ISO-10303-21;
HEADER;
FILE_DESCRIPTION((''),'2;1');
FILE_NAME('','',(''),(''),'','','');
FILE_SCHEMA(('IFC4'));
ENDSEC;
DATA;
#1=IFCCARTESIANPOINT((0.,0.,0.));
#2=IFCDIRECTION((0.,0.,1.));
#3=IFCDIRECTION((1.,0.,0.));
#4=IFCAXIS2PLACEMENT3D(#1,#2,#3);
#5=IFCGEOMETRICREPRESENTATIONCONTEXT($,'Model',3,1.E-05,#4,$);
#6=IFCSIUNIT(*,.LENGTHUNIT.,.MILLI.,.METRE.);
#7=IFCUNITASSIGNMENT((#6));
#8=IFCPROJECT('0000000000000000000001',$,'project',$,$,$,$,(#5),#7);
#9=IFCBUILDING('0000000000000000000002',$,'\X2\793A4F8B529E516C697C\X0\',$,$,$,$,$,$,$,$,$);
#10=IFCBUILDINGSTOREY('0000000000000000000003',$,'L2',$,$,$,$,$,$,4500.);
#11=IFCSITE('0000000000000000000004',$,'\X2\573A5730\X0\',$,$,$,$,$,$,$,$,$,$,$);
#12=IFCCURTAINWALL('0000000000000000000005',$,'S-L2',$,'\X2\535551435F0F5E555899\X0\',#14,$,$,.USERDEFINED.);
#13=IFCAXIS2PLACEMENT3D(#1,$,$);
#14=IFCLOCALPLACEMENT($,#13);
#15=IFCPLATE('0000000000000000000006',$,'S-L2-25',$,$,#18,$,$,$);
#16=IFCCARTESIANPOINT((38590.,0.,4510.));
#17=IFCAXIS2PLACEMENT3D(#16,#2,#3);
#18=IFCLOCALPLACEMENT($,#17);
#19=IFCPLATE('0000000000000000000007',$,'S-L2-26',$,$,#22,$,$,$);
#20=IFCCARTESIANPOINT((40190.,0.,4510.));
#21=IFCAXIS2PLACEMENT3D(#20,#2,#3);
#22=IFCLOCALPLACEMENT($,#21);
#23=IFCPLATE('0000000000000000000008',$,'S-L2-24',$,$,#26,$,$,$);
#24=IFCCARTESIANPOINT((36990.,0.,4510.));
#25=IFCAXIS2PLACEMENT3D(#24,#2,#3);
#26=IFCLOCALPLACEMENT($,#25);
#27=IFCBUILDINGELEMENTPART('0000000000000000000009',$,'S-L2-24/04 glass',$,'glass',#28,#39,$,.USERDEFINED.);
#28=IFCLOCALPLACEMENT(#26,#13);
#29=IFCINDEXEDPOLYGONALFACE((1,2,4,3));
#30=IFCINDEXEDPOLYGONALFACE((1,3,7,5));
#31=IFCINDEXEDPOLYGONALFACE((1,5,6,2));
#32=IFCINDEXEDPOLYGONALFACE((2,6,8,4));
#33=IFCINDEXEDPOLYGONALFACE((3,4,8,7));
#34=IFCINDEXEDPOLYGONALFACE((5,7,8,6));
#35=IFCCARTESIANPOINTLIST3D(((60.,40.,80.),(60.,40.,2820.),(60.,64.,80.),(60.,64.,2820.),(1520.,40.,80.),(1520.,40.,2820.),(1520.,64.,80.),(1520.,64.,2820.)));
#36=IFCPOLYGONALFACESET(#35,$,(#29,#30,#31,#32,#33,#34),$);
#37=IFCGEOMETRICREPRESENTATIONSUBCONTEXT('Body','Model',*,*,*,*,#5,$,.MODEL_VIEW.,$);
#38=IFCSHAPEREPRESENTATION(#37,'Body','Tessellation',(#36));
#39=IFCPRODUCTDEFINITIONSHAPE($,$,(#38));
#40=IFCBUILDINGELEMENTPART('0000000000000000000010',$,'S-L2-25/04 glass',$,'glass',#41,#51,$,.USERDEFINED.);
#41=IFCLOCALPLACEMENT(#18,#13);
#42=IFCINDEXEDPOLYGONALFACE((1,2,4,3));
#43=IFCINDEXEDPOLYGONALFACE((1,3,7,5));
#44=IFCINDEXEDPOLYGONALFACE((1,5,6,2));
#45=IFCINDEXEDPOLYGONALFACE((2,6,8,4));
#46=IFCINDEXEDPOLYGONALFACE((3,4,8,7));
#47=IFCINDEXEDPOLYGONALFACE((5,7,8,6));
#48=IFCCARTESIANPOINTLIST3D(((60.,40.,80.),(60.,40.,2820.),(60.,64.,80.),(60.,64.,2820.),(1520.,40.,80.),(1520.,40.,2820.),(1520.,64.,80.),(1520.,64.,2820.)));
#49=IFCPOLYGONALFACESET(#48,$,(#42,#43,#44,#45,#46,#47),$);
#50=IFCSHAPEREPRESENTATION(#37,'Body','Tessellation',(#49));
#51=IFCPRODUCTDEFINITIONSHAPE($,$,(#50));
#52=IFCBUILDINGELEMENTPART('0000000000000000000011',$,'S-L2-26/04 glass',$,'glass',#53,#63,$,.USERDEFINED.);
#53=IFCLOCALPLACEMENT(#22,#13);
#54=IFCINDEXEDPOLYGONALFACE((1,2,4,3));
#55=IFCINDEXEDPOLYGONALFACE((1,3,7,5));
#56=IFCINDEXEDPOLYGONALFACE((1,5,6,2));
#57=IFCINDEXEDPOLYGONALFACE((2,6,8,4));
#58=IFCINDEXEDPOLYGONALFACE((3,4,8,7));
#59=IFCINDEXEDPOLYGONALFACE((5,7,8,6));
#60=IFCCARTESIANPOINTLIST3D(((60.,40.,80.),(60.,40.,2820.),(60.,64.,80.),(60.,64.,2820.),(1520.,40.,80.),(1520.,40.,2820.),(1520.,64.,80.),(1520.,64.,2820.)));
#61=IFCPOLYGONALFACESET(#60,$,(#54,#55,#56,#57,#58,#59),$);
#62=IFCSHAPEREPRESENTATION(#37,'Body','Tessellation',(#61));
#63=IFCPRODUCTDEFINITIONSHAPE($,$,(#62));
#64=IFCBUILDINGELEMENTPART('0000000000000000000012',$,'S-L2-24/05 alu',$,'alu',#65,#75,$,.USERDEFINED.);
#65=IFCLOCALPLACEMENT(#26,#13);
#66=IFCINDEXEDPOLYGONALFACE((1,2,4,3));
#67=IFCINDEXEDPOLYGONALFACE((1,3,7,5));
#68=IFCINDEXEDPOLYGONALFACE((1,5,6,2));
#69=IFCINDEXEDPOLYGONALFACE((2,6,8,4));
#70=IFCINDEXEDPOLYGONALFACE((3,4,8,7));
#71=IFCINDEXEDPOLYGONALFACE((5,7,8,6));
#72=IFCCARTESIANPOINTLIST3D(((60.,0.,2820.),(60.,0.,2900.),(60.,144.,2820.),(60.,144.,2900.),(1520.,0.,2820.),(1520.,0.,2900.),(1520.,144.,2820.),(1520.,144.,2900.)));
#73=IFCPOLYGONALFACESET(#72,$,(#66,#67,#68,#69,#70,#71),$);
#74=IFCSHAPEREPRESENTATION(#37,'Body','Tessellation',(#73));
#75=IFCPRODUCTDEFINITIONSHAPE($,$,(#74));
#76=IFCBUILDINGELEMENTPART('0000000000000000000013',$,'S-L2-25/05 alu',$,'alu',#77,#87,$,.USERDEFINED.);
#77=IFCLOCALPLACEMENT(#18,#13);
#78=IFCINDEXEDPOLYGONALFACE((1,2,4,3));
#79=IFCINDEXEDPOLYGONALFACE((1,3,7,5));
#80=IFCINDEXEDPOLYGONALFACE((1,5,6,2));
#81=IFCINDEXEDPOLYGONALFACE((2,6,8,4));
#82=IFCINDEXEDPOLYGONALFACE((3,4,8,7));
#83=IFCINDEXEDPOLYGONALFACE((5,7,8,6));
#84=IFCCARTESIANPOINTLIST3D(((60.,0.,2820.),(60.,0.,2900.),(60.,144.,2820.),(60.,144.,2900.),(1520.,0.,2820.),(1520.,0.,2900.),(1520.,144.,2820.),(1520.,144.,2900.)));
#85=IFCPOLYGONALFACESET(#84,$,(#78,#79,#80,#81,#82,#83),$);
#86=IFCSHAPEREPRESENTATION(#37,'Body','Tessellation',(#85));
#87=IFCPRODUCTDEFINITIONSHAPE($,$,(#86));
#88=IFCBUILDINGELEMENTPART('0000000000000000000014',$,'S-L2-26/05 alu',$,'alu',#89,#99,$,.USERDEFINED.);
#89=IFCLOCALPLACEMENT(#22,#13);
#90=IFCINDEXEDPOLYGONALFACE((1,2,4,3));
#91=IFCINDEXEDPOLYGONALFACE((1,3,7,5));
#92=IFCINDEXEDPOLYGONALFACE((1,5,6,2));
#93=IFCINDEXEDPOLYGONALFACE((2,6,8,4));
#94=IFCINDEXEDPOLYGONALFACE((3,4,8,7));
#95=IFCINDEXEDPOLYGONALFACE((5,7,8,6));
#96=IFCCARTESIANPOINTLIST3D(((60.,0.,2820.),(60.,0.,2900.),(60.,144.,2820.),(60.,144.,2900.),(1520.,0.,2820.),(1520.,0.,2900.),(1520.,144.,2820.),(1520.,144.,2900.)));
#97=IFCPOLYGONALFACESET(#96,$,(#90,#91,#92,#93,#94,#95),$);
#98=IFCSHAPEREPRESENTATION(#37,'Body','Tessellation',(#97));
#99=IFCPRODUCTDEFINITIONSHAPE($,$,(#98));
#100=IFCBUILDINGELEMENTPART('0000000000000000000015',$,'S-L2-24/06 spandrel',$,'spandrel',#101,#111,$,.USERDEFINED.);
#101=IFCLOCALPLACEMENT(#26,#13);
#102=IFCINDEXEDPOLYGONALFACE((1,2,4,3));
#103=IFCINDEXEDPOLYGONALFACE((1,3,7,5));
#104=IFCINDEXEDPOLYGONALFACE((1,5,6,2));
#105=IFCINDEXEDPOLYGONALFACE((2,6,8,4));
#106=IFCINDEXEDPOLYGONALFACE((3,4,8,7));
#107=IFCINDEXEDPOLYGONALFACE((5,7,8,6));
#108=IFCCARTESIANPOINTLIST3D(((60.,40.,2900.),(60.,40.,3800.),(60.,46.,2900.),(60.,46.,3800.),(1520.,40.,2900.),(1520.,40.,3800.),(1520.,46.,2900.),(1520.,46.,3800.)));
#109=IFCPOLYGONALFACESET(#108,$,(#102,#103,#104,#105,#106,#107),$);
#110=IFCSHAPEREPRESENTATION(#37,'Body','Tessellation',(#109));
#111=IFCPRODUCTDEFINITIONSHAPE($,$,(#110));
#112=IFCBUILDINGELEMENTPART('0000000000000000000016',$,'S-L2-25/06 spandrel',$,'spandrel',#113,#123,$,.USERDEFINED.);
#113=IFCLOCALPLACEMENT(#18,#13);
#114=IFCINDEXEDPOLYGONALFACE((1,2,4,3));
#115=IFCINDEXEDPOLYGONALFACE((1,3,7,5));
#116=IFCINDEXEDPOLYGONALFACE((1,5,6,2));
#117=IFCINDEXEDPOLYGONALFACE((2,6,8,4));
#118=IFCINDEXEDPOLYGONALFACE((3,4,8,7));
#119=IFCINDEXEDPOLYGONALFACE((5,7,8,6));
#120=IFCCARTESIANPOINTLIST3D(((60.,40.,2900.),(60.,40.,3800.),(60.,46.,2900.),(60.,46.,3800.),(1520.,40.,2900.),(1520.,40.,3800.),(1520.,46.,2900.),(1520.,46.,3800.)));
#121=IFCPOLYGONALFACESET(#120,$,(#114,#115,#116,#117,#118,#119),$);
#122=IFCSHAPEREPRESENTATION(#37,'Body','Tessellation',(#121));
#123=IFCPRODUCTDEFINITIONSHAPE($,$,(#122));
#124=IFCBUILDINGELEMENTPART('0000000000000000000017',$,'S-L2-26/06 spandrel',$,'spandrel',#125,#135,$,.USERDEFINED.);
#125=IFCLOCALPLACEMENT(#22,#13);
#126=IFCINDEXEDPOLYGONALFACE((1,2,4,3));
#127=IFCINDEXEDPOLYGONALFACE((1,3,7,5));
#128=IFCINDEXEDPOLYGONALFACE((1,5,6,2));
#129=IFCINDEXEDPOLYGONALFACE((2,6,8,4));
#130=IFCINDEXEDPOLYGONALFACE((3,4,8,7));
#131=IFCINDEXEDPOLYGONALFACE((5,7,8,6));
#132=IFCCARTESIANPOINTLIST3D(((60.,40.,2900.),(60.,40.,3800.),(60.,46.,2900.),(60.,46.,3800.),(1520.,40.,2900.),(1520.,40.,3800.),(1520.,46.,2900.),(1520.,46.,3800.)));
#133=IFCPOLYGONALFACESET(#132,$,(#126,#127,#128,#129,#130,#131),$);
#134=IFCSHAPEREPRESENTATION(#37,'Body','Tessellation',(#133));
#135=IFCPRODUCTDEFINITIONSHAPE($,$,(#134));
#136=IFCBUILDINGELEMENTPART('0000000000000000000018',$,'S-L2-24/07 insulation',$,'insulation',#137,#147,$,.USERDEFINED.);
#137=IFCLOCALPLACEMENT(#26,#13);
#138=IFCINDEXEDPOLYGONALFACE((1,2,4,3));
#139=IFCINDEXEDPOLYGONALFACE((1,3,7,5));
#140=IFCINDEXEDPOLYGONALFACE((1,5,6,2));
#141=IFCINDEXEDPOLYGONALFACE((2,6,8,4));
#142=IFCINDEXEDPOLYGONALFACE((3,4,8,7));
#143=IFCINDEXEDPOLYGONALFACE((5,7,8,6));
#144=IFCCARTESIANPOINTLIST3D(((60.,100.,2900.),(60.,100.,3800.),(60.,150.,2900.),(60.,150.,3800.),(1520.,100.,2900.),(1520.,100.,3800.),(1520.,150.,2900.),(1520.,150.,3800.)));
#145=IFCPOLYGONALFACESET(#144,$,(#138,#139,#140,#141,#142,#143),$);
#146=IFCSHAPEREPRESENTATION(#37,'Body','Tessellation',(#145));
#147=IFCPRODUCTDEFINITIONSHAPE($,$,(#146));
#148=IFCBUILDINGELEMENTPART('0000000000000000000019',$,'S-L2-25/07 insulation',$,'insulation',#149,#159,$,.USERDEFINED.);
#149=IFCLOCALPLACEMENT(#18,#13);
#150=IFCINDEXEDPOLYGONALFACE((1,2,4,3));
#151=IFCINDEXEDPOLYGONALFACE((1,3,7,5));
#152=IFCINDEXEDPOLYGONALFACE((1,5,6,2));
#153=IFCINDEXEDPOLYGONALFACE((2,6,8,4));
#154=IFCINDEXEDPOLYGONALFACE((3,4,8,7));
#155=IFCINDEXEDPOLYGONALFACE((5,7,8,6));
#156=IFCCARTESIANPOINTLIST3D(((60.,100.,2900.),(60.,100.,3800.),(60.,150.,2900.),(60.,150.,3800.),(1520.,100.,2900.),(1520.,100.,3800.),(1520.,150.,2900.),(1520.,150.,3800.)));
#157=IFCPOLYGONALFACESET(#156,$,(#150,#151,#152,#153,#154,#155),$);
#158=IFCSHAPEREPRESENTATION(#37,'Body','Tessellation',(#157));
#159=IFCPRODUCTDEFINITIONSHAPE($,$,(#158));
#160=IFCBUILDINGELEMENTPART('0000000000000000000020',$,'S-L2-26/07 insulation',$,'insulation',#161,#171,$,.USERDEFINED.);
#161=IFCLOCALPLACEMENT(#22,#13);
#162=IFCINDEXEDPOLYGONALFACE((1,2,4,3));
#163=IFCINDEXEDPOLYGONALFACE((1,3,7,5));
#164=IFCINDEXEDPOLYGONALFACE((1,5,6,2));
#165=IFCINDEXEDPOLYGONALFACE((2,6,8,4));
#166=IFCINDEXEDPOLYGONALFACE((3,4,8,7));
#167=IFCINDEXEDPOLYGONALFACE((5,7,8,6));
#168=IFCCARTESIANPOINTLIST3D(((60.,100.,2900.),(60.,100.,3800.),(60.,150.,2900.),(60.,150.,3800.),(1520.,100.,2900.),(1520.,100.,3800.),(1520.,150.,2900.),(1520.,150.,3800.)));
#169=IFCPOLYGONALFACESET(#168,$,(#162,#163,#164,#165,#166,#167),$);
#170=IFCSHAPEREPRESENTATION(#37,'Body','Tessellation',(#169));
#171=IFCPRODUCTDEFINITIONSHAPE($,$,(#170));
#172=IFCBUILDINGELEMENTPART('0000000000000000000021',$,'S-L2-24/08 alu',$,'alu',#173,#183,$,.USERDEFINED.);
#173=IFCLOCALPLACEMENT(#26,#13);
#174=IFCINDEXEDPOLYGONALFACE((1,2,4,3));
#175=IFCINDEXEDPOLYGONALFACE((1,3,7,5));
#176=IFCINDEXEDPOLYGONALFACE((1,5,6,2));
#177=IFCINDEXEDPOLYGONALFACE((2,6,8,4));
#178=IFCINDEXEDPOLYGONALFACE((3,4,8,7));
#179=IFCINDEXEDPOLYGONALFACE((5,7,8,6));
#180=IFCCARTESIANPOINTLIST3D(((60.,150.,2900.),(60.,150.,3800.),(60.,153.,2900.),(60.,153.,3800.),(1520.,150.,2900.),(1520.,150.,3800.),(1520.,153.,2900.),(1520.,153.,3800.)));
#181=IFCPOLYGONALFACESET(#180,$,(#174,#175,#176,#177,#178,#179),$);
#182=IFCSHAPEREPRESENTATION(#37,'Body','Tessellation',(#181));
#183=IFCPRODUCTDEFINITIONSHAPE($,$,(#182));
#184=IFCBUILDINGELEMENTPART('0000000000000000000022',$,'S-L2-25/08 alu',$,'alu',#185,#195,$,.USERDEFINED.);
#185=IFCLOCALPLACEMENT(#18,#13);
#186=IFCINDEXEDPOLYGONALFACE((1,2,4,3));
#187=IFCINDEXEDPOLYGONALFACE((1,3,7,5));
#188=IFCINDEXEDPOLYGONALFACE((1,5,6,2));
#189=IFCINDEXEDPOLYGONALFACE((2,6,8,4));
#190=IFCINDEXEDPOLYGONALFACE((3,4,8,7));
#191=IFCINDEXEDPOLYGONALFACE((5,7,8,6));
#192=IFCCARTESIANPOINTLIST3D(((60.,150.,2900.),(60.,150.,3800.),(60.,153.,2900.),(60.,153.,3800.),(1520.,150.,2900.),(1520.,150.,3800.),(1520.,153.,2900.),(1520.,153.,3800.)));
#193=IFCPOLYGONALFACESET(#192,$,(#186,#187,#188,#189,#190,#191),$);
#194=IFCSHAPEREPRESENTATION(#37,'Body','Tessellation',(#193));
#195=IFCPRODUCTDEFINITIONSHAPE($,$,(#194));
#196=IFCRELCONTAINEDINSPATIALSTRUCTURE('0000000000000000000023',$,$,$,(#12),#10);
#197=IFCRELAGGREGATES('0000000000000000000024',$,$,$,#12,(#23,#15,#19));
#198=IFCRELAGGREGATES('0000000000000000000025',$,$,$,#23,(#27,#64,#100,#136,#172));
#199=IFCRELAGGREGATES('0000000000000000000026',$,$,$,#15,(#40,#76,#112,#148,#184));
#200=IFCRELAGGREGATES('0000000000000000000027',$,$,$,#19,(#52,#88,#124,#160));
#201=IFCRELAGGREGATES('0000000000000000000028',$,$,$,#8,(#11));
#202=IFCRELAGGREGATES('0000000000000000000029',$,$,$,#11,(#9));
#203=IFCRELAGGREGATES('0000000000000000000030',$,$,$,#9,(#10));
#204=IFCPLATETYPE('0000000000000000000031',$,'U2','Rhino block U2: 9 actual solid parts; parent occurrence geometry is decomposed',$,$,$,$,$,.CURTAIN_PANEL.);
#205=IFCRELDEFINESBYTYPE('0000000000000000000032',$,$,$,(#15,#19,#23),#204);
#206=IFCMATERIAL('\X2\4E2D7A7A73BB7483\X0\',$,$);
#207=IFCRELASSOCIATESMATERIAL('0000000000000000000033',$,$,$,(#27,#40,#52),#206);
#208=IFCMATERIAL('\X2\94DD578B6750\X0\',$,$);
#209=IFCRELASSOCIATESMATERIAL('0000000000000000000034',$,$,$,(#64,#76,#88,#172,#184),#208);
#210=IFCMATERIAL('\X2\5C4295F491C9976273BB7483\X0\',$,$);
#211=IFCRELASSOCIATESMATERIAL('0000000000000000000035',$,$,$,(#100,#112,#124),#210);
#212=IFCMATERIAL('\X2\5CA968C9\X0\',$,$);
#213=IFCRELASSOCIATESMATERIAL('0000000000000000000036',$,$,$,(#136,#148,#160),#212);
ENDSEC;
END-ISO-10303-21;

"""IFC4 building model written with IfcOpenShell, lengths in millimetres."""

from ifc_helpers import new_model, si_unit, frame, frame_2d, origin, origin_with_axes, place, context, subcontext, project, spatial, rectangle, extrude, source, transform, mapped, material, type_object, element, aggregate, save


model = new_model("IFC4")

# Units and contexts
model_context = context("Model", 3, precision=1e-05, world=origin_with_axes())
body_context = subcontext(model_context, "Body", "Model", "MODEL_VIEW")
ifc_project = project(units=[si_unit("LENGTHUNIT", "METRE", prefix="MILLI")], contexts=[model_context])

# Site, building, storey
site = spatial("IfcSite", under=ifc_project, Name="场地")
building = spatial("IfcBuilding", under=site, Name="示例办公楼")
storey = spatial("IfcBuildingStorey", under=building, Name="L2", Elevation=4500.0)

# Curtain wall, plates, building element parts
curtain_wall = element("IfcCurtainWall", 1, inside=storey, Name="S-L2", ObjectType="单元式幕墙", PredefinedType="USERDEFINED")
plate_type = type_object("IfcPlateType", Name="U2", Description="Rhino block U2: 9 actual solid parts; parent occurrence geometry is decomposed", PredefinedType="CURTAIN_PANEL")
plate_1_placement = place(None, frame((38590.0, 0.0, 4510.0), z_axis=(0.0, 0.0, 1.0), x_axis=(1.0, 0.0, 0.0)))
plate_1 = element("IfcPlate", 2, at=plate_1_placement, type_object=plate_type, Name="S-L2-25")
ifc_material_1 = material(Name="铝型材")
plate_2_placement = place(None, frame((40190.0, 0.0, 4510.0), z_axis=(0.0, 0.0, 1.0), x_axis=(1.0, 0.0, 0.0)))
plate_2 = element("IfcPlate", 3, at=plate_2_placement, type_object=plate_type, Name="S-L2-26")
plate_3_placement = place(None, frame((36990.0, 0.0, 4510.0), z_axis=(0.0, 0.0, 1.0), x_axis=(1.0, 0.0, 0.0)))
plate_3 = element("IfcPlate", 4, at=plate_3_placement, type_object=plate_type, Name="S-L2-24")
aggregate(curtain_wall, [plate_3, plate_1, plate_2])
ifc_material_2 = material(Name="中空玻璃")
shared_shape_1 = source(origin(), body_context, "Body", "SweptSolid", [
    extrude(rectangle(XDim=1460.0, YDim=24.0, at=frame_2d((790.0, 52.0))), frame((0.0, 0.0, 80.0)), (0.0, 0.0, 1.0), 2740.0),
])
building_element_part_1_placement = place(plate_3_placement, origin())
building_element_part_1 = element("IfcBuildingElementPart", 5, at=building_element_part_1_placement, material=ifc_material_2, Name="S-L2-24/04 glass", ObjectType="glass", PredefinedType="USERDEFINED", context=body_context, shape_type="MappedRepresentation", body=[
    mapped(shared_shape_1, transform((0.0, 0.0, 0.0))),
])
building_element_part_2_placement = place(plate_1_placement, origin())
building_element_part_2 = element("IfcBuildingElementPart", 6, at=building_element_part_2_placement, material=ifc_material_2, Name="S-L2-25/04 glass", ObjectType="glass", PredefinedType="USERDEFINED", context=body_context, shape_type="MappedRepresentation", body=[
    mapped(shared_shape_1, transform((0.0, 0.0, 0.0))),
])
building_element_part_3_placement = place(plate_2_placement, origin())
building_element_part_3 = element("IfcBuildingElementPart", 7, at=building_element_part_3_placement, material=ifc_material_2, Name="S-L2-26/04 glass", ObjectType="glass", PredefinedType="USERDEFINED", context=body_context, shape_type="MappedRepresentation", body=[
    mapped(shared_shape_1, transform((0.0, 0.0, 0.0))),
])
shared_shape_2 = source(origin(), body_context, "Body", "SweptSolid", [
    extrude(rectangle(XDim=1460.0, YDim=144.0, at=frame_2d((790.0, 72.0))), frame((0.0, 0.0, 2820.0)), (0.0, 0.0, 1.0), 80.0),
])
building_element_part_4_placement = place(plate_3_placement, origin())
building_element_part_4 = element("IfcBuildingElementPart", 8, at=building_element_part_4_placement, material=ifc_material_1, Name="S-L2-24/05 alu", ObjectType="alu", PredefinedType="USERDEFINED", context=body_context, shape_type="MappedRepresentation", body=[
    mapped(shared_shape_2, transform((0.0, 0.0, 0.0))),
])
building_element_part_5_placement = place(plate_1_placement, origin())
building_element_part_5 = element("IfcBuildingElementPart", 9, at=building_element_part_5_placement, material=ifc_material_1, Name="S-L2-25/05 alu", ObjectType="alu", PredefinedType="USERDEFINED", context=body_context, shape_type="MappedRepresentation", body=[
    mapped(shared_shape_2, transform((0.0, 0.0, 0.0))),
])
building_element_part_6_placement = place(plate_2_placement, origin())
building_element_part_6 = element("IfcBuildingElementPart", 10, at=building_element_part_6_placement, material=ifc_material_1, Name="S-L2-26/05 alu", ObjectType="alu", PredefinedType="USERDEFINED", context=body_context, shape_type="MappedRepresentation", body=[
    mapped(shared_shape_2, transform((0.0, 0.0, 0.0))),
])
ifc_material_3 = material(Name="层间釉面玻璃")
shared_shape_3 = source(origin(), body_context, "Body", "SweptSolid", [
    extrude(rectangle(XDim=1460.0, YDim=6.0, at=frame_2d((790.0, 43.0))), frame((0.0, 0.0, 2900.0)), (0.0, 0.0, 1.0), 900.0),
])
building_element_part_7_placement = place(plate_3_placement, origin())
building_element_part_7 = element("IfcBuildingElementPart", 11, at=building_element_part_7_placement, material=ifc_material_3, Name="S-L2-24/06 spandrel", ObjectType="spandrel", PredefinedType="USERDEFINED", context=body_context, shape_type="MappedRepresentation", body=[
    mapped(shared_shape_3, transform((0.0, 0.0, 0.0))),
])
building_element_part_8_placement = place(plate_1_placement, origin())
building_element_part_8 = element("IfcBuildingElementPart", 12, at=building_element_part_8_placement, material=ifc_material_3, Name="S-L2-25/06 spandrel", ObjectType="spandrel", PredefinedType="USERDEFINED", context=body_context, shape_type="MappedRepresentation", body=[
    mapped(shared_shape_3, transform((0.0, 0.0, 0.0))),
])
building_element_part_9_placement = place(plate_2_placement, origin())
building_element_part_9 = element("IfcBuildingElementPart", 13, at=building_element_part_9_placement, material=ifc_material_3, Name="S-L2-26/06 spandrel", ObjectType="spandrel", PredefinedType="USERDEFINED", context=body_context, shape_type="MappedRepresentation", body=[
    mapped(shared_shape_3, transform((0.0, 0.0, 0.0))),
])
ifc_material_4 = material(Name="岩棉")
shared_shape_4 = source(origin(), body_context, "Body", "SweptSolid", [
    extrude(rectangle(XDim=1460.0, YDim=50.0, at=frame_2d((790.0, 125.0))), frame((0.0, 0.0, 2900.0)), (0.0, 0.0, 1.0), 900.0),
])
building_element_part_10_placement = place(plate_3_placement, origin())
building_element_part_10 = element("IfcBuildingElementPart", 14, at=building_element_part_10_placement, material=ifc_material_4, Name="S-L2-24/07 insulation", ObjectType="insulation", PredefinedType="USERDEFINED", context=body_context, shape_type="MappedRepresentation", body=[
    mapped(shared_shape_4, transform((0.0, 0.0, 0.0))),
])
building_element_part_11_placement = place(plate_1_placement, origin())
building_element_part_11 = element("IfcBuildingElementPart", 15, at=building_element_part_11_placement, material=ifc_material_4, Name="S-L2-25/07 insulation", ObjectType="insulation", PredefinedType="USERDEFINED", context=body_context, shape_type="MappedRepresentation", body=[
    mapped(shared_shape_4, transform((0.0, 0.0, 0.0))),
])
building_element_part_12_placement = place(plate_2_placement, origin())
building_element_part_12 = element("IfcBuildingElementPart", 16, at=building_element_part_12_placement, material=ifc_material_4, Name="S-L2-26/07 insulation", ObjectType="insulation", PredefinedType="USERDEFINED", context=body_context, shape_type="MappedRepresentation", body=[
    mapped(shared_shape_4, transform((0.0, 0.0, 0.0))),
])
shared_shape_5 = source(origin(), body_context, "Body", "SweptSolid", [
    extrude(rectangle(XDim=1460.0, YDim=3.0, at=frame_2d((790.0, 151.5))), frame((0.0, 0.0, 2900.0)), (0.0, 0.0, 1.0), 900.0),
])
building_element_part_13_placement = place(plate_3_placement, origin())
building_element_part_13 = element("IfcBuildingElementPart", 17, at=building_element_part_13_placement, material=ifc_material_1, Name="S-L2-24/08 alu", ObjectType="alu", PredefinedType="USERDEFINED", context=body_context, shape_type="MappedRepresentation", body=[
    mapped(shared_shape_5, transform((0.0, 0.0, 0.0))),
])
building_element_part_14_placement = place(plate_1_placement, origin())
building_element_part_14 = element("IfcBuildingElementPart", 18, at=building_element_part_14_placement, material=ifc_material_1, Name="S-L2-25/08 alu", ObjectType="alu", PredefinedType="USERDEFINED", context=body_context, shape_type="MappedRepresentation", body=[
    mapped(shared_shape_5, transform((0.0, 0.0, 0.0))),
])
aggregate(plate_3, [building_element_part_1, building_element_part_4, building_element_part_7, building_element_part_10, building_element_part_13])
aggregate(plate_1, [building_element_part_2, building_element_part_5, building_element_part_8, building_element_part_11, building_element_part_14])
aggregate(plate_2, [building_element_part_3, building_element_part_6, building_element_part_9, building_element_part_12])

save(model, "model.ifc")
